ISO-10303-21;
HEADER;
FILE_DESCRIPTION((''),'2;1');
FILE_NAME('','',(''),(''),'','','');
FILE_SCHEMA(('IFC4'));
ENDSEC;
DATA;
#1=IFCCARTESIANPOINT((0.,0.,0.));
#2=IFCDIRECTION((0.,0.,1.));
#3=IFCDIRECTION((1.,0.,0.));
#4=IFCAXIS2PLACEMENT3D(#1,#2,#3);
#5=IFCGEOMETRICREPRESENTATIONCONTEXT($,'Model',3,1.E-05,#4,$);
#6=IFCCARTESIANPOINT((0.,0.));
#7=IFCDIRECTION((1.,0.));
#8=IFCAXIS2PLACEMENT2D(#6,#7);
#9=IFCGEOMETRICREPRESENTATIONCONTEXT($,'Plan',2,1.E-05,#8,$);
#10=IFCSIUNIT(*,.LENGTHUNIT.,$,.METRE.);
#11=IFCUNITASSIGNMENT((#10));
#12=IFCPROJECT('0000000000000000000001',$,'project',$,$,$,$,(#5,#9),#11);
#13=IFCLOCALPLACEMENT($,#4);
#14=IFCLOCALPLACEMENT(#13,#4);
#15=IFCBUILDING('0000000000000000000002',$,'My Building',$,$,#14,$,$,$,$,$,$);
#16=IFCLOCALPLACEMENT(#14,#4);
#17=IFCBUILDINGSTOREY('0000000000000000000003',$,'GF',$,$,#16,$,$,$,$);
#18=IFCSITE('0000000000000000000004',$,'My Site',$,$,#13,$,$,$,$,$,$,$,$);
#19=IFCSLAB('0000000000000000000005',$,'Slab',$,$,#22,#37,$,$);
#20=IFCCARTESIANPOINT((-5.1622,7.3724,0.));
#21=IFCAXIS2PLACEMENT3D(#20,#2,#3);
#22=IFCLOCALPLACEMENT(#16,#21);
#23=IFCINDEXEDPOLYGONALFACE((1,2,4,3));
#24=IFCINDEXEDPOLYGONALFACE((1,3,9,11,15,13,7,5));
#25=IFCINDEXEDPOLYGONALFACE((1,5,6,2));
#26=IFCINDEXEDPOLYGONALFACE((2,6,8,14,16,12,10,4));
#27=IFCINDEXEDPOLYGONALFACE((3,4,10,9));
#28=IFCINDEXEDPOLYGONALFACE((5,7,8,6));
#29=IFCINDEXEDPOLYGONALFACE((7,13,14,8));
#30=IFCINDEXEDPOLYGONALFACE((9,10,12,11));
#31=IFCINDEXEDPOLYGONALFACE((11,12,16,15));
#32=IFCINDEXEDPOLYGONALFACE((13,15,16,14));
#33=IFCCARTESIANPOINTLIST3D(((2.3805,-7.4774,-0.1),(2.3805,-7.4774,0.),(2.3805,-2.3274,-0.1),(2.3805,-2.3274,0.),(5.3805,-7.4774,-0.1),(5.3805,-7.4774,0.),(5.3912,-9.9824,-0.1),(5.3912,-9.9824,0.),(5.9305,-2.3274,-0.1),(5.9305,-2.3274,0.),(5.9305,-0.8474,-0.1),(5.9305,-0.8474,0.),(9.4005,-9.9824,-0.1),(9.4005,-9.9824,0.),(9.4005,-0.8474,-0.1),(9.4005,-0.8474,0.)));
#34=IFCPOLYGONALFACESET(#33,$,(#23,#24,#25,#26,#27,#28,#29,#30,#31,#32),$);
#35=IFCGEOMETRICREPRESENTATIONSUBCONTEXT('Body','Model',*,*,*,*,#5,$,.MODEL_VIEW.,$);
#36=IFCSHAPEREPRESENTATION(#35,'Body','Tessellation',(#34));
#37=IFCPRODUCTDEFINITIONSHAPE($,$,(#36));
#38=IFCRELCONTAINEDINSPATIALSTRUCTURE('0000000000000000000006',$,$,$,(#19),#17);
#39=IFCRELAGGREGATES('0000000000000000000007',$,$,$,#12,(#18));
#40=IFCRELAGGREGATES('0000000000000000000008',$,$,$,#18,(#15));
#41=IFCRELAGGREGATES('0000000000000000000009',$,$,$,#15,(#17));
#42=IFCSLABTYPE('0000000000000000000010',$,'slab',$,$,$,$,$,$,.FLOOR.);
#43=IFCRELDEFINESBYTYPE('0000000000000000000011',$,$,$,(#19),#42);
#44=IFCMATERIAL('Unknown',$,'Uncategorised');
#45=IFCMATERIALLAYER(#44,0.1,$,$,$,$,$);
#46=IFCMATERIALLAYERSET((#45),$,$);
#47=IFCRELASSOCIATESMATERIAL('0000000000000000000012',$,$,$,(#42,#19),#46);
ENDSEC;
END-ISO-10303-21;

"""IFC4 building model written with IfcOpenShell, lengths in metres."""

from ifc_helpers import new_model, si_unit, frame, origin_with_axes, origin_2d_with_axis, place, context, subcontext, project, spatial, indexed_curve, outline, extrude, material, layer, layer_set, layer_usage, type_object, element, save


model = new_model("IFC4")

# Units and contexts
model_context = context("Model", 3, precision=1e-05, world=origin_with_axes())
plan_context = context("Plan", 2, precision=1e-05, world=origin_2d_with_axis())
body_context_1 = subcontext(model_context, "Body", "Model", "MODEL_VIEW")
ifc_project = project(units=[si_unit("LENGTHUNIT", "METRE")], contexts=[model_context, plan_context])

# Site, building, storey
site_placement = place(None, origin_with_axes())
site = spatial("IfcSite", under=ifc_project, at=site_placement, Name="My Site")
building_placement = place(site_placement, origin_with_axes())
building = spatial("IfcBuilding", under=site, at=building_placement, Name="My Building")
storey_placement = place(building_placement, origin_with_axes())
storey = spatial("IfcBuildingStorey", under=building, at=storey_placement, Name="GF")

# Slab
ifc_material = material(Name="Unknown", Category="Uncategorised")
ifc_layer_1 = layer(ifc_material, 0.1)
ifc_layer_set_1 = layer_set([ifc_layer_1])
ifc_layer_usage_1 = layer_usage(ifc_layer_set_1, "AXIS3", "POSITIVE", -0.1)
slab_type = type_object("IfcSlabType", Name="slab", PredefinedType="FLOOR", material=ifc_layer_set_1)
slab_placement = place(storey_placement, frame((-5.1622, 7.3724, 0.0), z_axis=(0.0, 0.0, 1.0), x_axis=(1.0, 0.0, 0.0)))
element("IfcSlab", 1, at=slab_placement, inside=storey, type_object=slab_type, material=ifc_layer_usage_1, Name="Slab", context=body_context_1, shape_type="SweptSolid", body=[
    extrude(outline(indexed_curve([(5.9305, -2.3274), (5.9305, -0.8474), (9.4005, -0.8474), (9.4005, -9.9824), (5.3912, -9.9824), (5.3805, -7.4774), (2.3805, -7.4774), (2.3805, -2.3274), (5.9305, -2.3274)])), frame((0.0, 0.0, -0.1), z_axis=(0.0, 0.0, 1.0), x_axis=(1.0, 0.0, 0.0)), (0.0, 0.0, 1.0), 0.1),
])

save(model, "model.ifc")
